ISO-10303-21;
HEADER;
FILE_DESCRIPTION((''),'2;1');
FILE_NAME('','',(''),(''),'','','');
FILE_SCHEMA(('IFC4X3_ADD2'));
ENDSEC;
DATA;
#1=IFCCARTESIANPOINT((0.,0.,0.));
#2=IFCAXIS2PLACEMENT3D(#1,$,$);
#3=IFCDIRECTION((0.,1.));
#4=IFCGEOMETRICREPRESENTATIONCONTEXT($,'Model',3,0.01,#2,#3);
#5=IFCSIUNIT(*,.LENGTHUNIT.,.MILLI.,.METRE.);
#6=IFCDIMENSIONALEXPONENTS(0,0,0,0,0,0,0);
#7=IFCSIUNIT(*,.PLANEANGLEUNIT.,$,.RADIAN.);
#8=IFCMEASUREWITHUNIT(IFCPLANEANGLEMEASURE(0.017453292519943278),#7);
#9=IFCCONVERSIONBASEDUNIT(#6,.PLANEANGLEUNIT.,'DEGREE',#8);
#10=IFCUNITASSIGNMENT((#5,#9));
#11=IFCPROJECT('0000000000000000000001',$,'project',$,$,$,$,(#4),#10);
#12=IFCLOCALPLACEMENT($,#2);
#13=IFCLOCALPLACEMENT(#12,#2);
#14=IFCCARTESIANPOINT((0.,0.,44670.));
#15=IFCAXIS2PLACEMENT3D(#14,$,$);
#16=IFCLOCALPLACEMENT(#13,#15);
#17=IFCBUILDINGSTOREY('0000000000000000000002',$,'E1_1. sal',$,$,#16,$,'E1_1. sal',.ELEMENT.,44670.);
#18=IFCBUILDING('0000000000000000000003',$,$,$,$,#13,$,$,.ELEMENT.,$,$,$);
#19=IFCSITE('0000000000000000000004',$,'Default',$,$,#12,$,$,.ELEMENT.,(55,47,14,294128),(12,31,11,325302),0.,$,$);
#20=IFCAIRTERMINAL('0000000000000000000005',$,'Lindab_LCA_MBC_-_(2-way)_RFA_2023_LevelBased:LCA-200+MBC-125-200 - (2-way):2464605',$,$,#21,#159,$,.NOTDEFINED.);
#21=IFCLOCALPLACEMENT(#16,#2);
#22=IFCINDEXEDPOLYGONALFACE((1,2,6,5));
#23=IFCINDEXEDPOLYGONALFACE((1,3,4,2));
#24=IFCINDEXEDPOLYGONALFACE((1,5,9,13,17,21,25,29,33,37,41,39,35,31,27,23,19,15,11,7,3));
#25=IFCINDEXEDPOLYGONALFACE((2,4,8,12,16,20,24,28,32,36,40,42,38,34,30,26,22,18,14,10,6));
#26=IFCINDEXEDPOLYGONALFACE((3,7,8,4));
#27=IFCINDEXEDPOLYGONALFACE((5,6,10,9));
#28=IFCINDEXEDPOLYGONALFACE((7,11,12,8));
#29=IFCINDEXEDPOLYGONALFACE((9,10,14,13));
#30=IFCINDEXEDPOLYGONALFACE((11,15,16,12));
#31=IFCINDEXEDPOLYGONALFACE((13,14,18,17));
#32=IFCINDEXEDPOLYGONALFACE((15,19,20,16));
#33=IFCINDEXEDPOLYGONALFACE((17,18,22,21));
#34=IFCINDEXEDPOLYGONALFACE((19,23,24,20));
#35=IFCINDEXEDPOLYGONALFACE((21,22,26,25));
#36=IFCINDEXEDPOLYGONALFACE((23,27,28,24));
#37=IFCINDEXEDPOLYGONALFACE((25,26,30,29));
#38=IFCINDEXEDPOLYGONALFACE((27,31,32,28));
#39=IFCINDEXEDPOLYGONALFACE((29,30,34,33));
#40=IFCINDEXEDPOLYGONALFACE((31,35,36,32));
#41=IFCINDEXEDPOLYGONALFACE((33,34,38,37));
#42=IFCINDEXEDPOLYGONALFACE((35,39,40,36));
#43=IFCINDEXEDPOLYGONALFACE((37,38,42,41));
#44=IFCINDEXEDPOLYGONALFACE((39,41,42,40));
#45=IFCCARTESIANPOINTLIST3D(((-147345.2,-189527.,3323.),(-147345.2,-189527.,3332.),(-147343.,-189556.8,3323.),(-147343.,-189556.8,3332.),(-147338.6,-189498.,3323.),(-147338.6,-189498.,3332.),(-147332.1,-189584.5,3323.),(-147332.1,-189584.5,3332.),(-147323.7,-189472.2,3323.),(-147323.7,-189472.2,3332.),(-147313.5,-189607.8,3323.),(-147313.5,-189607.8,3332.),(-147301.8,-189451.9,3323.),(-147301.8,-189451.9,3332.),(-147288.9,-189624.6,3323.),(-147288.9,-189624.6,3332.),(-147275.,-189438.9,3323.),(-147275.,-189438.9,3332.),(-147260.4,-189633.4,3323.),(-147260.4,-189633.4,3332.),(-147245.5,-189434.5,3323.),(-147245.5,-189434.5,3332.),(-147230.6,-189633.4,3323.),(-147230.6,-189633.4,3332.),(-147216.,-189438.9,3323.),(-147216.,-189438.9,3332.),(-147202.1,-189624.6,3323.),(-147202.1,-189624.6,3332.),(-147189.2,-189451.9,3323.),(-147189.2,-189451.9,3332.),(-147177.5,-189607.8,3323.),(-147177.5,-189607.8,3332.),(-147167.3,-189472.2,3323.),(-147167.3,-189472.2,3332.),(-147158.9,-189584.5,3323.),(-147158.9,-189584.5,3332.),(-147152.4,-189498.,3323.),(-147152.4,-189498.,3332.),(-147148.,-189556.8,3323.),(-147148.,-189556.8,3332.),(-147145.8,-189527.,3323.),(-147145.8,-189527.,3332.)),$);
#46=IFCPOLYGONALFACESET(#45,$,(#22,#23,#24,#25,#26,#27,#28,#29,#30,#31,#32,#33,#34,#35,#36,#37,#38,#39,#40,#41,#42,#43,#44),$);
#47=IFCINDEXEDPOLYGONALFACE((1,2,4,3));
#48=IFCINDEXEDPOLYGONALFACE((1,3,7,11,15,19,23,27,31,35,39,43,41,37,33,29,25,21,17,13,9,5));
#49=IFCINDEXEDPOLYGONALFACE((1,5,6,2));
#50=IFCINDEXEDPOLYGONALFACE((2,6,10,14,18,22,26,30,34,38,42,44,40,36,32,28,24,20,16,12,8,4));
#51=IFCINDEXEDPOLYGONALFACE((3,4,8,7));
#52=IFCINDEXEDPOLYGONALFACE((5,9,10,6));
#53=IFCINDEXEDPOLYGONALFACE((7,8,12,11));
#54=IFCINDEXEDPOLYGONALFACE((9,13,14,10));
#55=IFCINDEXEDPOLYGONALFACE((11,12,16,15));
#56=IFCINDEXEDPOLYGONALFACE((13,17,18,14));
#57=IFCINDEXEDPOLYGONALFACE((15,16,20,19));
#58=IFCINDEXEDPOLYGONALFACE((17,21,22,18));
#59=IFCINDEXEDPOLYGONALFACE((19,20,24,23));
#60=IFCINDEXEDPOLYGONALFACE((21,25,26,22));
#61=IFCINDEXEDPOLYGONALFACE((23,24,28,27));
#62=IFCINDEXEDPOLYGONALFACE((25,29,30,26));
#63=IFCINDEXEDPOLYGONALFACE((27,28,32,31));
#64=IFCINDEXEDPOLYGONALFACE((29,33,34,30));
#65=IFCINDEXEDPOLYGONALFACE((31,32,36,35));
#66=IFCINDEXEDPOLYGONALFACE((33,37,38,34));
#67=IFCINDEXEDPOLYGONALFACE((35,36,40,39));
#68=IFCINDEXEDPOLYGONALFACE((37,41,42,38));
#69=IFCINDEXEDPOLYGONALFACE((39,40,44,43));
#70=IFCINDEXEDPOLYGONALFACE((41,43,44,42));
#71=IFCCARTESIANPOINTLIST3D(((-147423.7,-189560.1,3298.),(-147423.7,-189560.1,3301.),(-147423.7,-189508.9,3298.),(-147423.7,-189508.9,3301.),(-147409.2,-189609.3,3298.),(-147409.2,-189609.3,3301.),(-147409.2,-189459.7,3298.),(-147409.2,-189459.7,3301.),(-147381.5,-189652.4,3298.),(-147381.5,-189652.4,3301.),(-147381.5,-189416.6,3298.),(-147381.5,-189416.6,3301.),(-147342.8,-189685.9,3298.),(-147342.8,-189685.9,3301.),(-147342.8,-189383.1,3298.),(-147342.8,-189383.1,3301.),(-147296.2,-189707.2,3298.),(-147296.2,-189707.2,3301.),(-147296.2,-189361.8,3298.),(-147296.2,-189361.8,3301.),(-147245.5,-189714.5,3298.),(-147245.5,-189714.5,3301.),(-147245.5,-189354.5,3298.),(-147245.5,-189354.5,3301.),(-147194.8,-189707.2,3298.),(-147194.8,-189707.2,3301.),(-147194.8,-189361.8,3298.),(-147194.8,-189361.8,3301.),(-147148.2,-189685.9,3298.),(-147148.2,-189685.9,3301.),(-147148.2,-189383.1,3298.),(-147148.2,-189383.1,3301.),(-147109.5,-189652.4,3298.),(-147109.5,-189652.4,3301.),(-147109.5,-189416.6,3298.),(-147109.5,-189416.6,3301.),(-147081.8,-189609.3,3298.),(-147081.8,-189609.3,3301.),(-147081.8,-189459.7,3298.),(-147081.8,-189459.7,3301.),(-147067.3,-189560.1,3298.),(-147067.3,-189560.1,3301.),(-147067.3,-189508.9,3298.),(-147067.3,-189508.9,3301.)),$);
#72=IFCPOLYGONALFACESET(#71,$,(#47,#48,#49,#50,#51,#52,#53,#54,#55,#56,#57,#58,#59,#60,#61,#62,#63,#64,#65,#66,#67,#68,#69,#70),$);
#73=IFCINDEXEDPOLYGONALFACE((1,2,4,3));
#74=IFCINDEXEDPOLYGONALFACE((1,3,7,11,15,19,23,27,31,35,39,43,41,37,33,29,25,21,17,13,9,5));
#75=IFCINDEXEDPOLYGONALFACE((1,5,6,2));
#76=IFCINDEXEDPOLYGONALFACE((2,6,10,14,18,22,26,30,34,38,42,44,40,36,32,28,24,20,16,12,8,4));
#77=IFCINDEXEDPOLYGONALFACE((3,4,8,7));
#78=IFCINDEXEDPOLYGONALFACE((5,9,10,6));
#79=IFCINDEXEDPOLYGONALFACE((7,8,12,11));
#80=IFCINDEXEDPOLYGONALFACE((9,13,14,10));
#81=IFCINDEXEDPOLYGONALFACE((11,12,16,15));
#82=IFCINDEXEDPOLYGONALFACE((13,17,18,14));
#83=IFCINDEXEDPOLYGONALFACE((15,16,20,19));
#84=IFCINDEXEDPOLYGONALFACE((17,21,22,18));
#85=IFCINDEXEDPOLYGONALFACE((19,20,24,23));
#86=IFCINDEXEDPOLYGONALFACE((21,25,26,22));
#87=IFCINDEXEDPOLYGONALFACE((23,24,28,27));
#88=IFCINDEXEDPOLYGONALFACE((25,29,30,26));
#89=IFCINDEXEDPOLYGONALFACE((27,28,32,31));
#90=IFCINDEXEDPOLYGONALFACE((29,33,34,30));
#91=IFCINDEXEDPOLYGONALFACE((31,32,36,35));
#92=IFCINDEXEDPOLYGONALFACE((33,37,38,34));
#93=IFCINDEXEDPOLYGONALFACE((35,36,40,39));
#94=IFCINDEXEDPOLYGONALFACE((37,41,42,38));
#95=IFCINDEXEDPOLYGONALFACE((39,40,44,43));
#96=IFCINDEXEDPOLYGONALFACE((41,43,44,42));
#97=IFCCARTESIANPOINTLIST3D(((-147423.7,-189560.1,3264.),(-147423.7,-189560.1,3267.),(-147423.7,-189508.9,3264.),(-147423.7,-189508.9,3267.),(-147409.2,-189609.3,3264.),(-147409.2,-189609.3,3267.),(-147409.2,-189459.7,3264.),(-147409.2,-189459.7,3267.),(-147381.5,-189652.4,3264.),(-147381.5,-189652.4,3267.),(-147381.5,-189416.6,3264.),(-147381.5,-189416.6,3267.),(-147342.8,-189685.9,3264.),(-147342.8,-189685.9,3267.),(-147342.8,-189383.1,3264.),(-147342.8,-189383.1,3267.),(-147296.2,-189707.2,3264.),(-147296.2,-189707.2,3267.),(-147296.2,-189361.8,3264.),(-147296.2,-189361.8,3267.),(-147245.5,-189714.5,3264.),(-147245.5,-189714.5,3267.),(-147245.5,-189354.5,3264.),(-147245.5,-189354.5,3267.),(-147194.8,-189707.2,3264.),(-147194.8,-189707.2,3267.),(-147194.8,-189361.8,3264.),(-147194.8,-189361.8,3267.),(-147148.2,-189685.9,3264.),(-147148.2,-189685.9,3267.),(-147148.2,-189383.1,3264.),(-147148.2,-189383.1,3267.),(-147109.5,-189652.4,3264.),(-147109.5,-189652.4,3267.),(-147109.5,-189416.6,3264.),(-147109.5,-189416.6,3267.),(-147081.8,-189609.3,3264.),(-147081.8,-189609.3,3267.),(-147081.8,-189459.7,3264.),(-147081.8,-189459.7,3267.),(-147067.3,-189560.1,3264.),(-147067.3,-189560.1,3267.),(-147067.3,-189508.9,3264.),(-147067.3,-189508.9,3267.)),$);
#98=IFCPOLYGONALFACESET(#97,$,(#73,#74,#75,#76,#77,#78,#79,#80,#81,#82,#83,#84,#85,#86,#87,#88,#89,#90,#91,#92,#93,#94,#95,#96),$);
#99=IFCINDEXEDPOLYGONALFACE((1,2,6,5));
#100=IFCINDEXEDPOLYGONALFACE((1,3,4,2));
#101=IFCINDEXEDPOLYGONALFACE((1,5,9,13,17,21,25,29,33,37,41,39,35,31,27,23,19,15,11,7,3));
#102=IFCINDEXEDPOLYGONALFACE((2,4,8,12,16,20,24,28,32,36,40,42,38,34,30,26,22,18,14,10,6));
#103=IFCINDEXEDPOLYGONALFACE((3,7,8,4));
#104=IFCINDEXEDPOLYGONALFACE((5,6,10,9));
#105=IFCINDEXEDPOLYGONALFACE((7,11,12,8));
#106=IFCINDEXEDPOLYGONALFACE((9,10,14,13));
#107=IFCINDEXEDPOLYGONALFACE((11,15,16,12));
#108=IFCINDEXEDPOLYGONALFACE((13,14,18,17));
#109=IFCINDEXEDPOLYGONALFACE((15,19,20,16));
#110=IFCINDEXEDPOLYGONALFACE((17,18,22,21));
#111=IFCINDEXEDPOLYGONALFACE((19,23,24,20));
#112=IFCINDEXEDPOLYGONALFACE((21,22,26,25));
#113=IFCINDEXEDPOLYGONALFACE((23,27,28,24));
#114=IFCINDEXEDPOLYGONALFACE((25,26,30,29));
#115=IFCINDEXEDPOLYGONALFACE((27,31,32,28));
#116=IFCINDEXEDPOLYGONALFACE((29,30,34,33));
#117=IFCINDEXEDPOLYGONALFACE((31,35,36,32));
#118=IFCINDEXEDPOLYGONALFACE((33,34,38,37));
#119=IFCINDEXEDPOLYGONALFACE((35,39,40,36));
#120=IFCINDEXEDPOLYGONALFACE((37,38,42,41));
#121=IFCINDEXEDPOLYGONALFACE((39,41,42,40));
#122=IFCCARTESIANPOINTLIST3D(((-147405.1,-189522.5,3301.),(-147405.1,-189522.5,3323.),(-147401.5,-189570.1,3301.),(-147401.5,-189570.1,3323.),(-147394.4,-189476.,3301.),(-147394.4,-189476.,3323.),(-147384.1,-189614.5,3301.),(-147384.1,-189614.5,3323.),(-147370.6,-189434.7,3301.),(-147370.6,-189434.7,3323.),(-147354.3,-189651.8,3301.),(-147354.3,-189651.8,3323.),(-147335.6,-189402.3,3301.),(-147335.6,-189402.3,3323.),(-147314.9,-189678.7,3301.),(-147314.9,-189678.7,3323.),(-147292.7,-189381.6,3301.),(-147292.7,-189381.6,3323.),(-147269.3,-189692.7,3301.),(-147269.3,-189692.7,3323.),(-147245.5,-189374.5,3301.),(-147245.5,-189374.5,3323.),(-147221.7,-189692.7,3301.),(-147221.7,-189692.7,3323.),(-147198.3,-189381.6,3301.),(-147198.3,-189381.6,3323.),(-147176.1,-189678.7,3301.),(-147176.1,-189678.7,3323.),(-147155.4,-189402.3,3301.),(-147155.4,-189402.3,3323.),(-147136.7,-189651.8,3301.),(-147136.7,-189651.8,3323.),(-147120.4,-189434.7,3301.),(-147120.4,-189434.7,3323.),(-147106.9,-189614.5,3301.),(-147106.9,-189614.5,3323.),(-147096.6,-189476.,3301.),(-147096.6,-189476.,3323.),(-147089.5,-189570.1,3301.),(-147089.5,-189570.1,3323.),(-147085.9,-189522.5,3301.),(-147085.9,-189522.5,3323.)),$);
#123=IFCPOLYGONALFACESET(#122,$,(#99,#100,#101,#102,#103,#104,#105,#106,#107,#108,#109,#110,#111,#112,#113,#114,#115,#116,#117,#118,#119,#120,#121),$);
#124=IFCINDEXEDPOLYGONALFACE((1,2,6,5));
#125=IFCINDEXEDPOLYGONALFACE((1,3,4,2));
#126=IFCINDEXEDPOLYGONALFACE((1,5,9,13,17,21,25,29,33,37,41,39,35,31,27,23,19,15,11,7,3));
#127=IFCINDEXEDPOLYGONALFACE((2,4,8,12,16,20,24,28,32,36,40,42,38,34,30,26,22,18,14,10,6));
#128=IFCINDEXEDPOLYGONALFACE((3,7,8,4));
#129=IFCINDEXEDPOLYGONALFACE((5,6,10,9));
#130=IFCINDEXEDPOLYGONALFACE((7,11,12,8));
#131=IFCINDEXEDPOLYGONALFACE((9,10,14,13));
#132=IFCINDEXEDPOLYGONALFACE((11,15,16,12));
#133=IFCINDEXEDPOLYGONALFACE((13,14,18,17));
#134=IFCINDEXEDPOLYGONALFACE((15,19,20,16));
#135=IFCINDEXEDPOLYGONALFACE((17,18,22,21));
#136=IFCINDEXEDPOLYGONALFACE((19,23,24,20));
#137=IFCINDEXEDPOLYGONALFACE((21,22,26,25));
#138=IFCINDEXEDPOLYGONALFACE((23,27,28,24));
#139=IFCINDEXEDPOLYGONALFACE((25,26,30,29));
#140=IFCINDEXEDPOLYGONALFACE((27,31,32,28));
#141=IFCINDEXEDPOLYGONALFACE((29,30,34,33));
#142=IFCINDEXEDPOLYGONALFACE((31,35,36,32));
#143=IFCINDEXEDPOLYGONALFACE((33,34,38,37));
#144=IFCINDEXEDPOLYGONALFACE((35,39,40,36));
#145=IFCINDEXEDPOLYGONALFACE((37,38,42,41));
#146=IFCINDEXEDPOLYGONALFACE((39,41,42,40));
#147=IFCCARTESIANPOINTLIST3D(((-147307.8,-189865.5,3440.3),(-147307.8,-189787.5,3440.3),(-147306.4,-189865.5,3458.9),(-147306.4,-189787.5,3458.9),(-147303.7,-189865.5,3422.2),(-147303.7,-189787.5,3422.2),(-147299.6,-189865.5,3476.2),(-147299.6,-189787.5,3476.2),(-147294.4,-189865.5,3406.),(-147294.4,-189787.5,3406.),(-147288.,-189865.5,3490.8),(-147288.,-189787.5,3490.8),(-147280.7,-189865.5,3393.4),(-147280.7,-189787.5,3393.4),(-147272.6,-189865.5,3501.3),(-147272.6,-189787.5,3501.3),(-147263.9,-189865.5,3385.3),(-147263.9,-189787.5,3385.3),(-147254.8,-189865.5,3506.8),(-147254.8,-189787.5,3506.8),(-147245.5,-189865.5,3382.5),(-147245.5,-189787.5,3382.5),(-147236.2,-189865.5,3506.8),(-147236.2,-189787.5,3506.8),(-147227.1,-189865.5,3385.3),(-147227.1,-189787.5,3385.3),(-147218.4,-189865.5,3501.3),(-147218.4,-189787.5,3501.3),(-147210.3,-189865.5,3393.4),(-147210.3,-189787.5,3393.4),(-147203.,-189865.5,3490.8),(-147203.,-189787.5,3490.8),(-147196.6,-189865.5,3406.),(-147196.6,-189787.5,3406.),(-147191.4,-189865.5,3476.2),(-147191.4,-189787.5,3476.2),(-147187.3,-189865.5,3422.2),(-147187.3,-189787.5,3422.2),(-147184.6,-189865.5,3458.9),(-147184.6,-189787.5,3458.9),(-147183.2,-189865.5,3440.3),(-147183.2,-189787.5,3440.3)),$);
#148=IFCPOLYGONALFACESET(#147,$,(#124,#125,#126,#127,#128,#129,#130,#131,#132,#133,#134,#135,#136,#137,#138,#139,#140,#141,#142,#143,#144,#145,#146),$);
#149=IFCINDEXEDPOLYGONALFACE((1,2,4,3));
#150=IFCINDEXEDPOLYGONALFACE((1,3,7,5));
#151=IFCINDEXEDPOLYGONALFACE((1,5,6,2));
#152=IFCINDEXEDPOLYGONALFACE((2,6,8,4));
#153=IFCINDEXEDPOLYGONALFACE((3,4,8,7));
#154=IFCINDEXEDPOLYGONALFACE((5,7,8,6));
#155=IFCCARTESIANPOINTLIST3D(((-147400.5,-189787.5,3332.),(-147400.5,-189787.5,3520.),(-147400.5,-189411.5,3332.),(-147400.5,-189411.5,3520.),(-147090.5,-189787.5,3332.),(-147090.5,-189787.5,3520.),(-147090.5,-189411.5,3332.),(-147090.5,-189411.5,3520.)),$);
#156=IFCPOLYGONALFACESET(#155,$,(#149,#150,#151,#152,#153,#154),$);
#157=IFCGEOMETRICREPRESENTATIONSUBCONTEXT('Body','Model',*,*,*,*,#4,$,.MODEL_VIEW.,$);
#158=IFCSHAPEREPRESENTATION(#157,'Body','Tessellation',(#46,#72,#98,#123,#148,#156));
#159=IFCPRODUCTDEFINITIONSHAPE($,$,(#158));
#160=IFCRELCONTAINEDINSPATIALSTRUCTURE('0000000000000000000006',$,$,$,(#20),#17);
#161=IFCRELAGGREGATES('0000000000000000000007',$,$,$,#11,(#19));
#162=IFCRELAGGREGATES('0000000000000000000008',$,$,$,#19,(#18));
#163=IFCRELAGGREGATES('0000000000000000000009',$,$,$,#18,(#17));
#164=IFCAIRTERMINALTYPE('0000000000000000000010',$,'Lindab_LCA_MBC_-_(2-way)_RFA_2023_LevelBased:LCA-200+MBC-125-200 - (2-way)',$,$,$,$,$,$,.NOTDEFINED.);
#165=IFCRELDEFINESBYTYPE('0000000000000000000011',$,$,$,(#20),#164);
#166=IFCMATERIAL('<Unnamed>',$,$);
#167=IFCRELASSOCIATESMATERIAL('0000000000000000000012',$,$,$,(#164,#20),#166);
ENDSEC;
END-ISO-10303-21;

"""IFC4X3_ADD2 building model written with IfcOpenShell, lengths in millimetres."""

from ifc_helpers import new_model, entity, si_unit, converted_unit, direction, frame, frame_2d, origin, origin_2d_with_axis, place, context, subcontext, project, spatial, rectangle, circle, extrude, source, transform, mapped, material, type_object, type_shapes, element, save


model = new_model("IFC4X3_ADD2")

# Units and contexts
model_context = context("Model", 3, precision=0.01, world=origin(), true_north=direction((0.0, 1.0)))
body_context = subcontext(model_context, "Body", "Model", "MODEL_VIEW")
ifc_project = project(units=[si_unit("LENGTHUNIT", "METRE", prefix="MILLI"), converted_unit("PLANEANGLEUNIT", "DEGREE", entity("IfcPlaneAngleMeasure", 0.017453292519943278), si_unit("PLANEANGLEUNIT", "RADIAN"), dimensions=[0, 0, 0, 0, 0, 0, 0])], contexts=[model_context])

# Site, building, storey
site_placement = place(None, origin())
site = spatial("IfcSite", under=ifc_project, at=site_placement, Name="Default", CompositionType="ELEMENT", RefLatitude=(55, 47, 14, 294128), RefLongitude=(12, 31, 11, 325302), RefElevation=0.0)
building_placement = place(site_placement, origin())
building = spatial("IfcBuilding", under=site, at=building_placement, CompositionType="ELEMENT")
storey_placement = place(building_placement, frame((0.0, 0.0, 44670.0)))
storey = spatial("IfcBuildingStorey", under=building, at=storey_placement, Name="E1_1. sal", LongName="E1_1. sal", CompositionType="ELEMENT", Elevation=44670.0)

# Air terminal
ifc_material_1 = material(Name="<Unnamed>")
air_terminal_type = type_object("IfcAirTerminalType", Name="Lindab_LCA_MBC_-_(2-way)_RFA_2023_LevelBased:LCA-200+MBC-125-200 - (2-way)", PredefinedType="NOTDEFINED", material=ifc_material_1)
shared_shape_1 = source(origin(), body_context, "Body", "SweptSolid", [
    extrude(circle(Radius=100.0, at=frame_2d((0.0, 0.0), x_axis=(1.0, 0.0))), frame((0.0, 0.0, 22.0)), (0.0, 0.0, 1.0), 9.0),
    extrude(circle(Radius=180.0, at=frame_2d((0.0, 0.0), x_axis=(1.0, 0.0))), frame((0.0, 0.0, -3.0)), (0.0, 0.0, 1.0), 3.0),
    extrude(circle(Radius=180.0, at=frame_2d((0.0, 0.0), x_axis=(1.0, 0.0))), frame((0.0, 0.0, -37.0)), (0.0, 0.0, 1.0), 3.0),
    extrude(circle(Radius=160.0, at=frame_2d((0.0, 0.0), x_axis=(1.0, 0.0))), origin(), (0.0, 0.0, 1.0), 22.0),
    extrude(circle(Radius=62.5, at=frame_2d((0.0, 0.0), x_axis=(1.0, 0.0))), frame((-331.0, 0.0, 144.0), z_axis=(1.0, 0.0, 0.0), x_axis=(0.0, 0.0, -1.0)), (0.0, 0.0, 1.0), 78.0),
    extrude(rectangle(XDim=310.0, YDim=376.0, at=origin_2d_with_axis()), frame((-65.0, 0.0, 31.0), z_axis=(0.0, 0.0, 1.0), x_axis=(0.0, -1.0, 0.0)), (0.0, 0.0, 1.0), 188.0),
])
type_shapes(air_terminal_type, [shared_shape_1])
for number, where, z_axis, x_axis, name in (
    (1, (-147245.5, -189534.5, 3301.0), (0.0, 0.0, 1.0), (0.0, 1.0, 0.0), "Lindab_LCA_MBC_-_(2-way)_RFA_2023_LevelBased:LCA-200+MBC-125-200 - (2-way):2464605"),
):
    element("IfcAirTerminal", number, at=place(storey_placement, frame(where, z_axis=z_axis, x_axis=x_axis)), inside=storey, type_object=air_terminal_type, material=ifc_material_1, Name=name, PredefinedType="NOTDEFINED", context=body_context, shape_type="MappedRepresentation", body=[
        mapped(shared_shape_1, transform((0.0, 0.0, 0.0), scale=1.0)),
    ])

save(model, "model.ifc")
